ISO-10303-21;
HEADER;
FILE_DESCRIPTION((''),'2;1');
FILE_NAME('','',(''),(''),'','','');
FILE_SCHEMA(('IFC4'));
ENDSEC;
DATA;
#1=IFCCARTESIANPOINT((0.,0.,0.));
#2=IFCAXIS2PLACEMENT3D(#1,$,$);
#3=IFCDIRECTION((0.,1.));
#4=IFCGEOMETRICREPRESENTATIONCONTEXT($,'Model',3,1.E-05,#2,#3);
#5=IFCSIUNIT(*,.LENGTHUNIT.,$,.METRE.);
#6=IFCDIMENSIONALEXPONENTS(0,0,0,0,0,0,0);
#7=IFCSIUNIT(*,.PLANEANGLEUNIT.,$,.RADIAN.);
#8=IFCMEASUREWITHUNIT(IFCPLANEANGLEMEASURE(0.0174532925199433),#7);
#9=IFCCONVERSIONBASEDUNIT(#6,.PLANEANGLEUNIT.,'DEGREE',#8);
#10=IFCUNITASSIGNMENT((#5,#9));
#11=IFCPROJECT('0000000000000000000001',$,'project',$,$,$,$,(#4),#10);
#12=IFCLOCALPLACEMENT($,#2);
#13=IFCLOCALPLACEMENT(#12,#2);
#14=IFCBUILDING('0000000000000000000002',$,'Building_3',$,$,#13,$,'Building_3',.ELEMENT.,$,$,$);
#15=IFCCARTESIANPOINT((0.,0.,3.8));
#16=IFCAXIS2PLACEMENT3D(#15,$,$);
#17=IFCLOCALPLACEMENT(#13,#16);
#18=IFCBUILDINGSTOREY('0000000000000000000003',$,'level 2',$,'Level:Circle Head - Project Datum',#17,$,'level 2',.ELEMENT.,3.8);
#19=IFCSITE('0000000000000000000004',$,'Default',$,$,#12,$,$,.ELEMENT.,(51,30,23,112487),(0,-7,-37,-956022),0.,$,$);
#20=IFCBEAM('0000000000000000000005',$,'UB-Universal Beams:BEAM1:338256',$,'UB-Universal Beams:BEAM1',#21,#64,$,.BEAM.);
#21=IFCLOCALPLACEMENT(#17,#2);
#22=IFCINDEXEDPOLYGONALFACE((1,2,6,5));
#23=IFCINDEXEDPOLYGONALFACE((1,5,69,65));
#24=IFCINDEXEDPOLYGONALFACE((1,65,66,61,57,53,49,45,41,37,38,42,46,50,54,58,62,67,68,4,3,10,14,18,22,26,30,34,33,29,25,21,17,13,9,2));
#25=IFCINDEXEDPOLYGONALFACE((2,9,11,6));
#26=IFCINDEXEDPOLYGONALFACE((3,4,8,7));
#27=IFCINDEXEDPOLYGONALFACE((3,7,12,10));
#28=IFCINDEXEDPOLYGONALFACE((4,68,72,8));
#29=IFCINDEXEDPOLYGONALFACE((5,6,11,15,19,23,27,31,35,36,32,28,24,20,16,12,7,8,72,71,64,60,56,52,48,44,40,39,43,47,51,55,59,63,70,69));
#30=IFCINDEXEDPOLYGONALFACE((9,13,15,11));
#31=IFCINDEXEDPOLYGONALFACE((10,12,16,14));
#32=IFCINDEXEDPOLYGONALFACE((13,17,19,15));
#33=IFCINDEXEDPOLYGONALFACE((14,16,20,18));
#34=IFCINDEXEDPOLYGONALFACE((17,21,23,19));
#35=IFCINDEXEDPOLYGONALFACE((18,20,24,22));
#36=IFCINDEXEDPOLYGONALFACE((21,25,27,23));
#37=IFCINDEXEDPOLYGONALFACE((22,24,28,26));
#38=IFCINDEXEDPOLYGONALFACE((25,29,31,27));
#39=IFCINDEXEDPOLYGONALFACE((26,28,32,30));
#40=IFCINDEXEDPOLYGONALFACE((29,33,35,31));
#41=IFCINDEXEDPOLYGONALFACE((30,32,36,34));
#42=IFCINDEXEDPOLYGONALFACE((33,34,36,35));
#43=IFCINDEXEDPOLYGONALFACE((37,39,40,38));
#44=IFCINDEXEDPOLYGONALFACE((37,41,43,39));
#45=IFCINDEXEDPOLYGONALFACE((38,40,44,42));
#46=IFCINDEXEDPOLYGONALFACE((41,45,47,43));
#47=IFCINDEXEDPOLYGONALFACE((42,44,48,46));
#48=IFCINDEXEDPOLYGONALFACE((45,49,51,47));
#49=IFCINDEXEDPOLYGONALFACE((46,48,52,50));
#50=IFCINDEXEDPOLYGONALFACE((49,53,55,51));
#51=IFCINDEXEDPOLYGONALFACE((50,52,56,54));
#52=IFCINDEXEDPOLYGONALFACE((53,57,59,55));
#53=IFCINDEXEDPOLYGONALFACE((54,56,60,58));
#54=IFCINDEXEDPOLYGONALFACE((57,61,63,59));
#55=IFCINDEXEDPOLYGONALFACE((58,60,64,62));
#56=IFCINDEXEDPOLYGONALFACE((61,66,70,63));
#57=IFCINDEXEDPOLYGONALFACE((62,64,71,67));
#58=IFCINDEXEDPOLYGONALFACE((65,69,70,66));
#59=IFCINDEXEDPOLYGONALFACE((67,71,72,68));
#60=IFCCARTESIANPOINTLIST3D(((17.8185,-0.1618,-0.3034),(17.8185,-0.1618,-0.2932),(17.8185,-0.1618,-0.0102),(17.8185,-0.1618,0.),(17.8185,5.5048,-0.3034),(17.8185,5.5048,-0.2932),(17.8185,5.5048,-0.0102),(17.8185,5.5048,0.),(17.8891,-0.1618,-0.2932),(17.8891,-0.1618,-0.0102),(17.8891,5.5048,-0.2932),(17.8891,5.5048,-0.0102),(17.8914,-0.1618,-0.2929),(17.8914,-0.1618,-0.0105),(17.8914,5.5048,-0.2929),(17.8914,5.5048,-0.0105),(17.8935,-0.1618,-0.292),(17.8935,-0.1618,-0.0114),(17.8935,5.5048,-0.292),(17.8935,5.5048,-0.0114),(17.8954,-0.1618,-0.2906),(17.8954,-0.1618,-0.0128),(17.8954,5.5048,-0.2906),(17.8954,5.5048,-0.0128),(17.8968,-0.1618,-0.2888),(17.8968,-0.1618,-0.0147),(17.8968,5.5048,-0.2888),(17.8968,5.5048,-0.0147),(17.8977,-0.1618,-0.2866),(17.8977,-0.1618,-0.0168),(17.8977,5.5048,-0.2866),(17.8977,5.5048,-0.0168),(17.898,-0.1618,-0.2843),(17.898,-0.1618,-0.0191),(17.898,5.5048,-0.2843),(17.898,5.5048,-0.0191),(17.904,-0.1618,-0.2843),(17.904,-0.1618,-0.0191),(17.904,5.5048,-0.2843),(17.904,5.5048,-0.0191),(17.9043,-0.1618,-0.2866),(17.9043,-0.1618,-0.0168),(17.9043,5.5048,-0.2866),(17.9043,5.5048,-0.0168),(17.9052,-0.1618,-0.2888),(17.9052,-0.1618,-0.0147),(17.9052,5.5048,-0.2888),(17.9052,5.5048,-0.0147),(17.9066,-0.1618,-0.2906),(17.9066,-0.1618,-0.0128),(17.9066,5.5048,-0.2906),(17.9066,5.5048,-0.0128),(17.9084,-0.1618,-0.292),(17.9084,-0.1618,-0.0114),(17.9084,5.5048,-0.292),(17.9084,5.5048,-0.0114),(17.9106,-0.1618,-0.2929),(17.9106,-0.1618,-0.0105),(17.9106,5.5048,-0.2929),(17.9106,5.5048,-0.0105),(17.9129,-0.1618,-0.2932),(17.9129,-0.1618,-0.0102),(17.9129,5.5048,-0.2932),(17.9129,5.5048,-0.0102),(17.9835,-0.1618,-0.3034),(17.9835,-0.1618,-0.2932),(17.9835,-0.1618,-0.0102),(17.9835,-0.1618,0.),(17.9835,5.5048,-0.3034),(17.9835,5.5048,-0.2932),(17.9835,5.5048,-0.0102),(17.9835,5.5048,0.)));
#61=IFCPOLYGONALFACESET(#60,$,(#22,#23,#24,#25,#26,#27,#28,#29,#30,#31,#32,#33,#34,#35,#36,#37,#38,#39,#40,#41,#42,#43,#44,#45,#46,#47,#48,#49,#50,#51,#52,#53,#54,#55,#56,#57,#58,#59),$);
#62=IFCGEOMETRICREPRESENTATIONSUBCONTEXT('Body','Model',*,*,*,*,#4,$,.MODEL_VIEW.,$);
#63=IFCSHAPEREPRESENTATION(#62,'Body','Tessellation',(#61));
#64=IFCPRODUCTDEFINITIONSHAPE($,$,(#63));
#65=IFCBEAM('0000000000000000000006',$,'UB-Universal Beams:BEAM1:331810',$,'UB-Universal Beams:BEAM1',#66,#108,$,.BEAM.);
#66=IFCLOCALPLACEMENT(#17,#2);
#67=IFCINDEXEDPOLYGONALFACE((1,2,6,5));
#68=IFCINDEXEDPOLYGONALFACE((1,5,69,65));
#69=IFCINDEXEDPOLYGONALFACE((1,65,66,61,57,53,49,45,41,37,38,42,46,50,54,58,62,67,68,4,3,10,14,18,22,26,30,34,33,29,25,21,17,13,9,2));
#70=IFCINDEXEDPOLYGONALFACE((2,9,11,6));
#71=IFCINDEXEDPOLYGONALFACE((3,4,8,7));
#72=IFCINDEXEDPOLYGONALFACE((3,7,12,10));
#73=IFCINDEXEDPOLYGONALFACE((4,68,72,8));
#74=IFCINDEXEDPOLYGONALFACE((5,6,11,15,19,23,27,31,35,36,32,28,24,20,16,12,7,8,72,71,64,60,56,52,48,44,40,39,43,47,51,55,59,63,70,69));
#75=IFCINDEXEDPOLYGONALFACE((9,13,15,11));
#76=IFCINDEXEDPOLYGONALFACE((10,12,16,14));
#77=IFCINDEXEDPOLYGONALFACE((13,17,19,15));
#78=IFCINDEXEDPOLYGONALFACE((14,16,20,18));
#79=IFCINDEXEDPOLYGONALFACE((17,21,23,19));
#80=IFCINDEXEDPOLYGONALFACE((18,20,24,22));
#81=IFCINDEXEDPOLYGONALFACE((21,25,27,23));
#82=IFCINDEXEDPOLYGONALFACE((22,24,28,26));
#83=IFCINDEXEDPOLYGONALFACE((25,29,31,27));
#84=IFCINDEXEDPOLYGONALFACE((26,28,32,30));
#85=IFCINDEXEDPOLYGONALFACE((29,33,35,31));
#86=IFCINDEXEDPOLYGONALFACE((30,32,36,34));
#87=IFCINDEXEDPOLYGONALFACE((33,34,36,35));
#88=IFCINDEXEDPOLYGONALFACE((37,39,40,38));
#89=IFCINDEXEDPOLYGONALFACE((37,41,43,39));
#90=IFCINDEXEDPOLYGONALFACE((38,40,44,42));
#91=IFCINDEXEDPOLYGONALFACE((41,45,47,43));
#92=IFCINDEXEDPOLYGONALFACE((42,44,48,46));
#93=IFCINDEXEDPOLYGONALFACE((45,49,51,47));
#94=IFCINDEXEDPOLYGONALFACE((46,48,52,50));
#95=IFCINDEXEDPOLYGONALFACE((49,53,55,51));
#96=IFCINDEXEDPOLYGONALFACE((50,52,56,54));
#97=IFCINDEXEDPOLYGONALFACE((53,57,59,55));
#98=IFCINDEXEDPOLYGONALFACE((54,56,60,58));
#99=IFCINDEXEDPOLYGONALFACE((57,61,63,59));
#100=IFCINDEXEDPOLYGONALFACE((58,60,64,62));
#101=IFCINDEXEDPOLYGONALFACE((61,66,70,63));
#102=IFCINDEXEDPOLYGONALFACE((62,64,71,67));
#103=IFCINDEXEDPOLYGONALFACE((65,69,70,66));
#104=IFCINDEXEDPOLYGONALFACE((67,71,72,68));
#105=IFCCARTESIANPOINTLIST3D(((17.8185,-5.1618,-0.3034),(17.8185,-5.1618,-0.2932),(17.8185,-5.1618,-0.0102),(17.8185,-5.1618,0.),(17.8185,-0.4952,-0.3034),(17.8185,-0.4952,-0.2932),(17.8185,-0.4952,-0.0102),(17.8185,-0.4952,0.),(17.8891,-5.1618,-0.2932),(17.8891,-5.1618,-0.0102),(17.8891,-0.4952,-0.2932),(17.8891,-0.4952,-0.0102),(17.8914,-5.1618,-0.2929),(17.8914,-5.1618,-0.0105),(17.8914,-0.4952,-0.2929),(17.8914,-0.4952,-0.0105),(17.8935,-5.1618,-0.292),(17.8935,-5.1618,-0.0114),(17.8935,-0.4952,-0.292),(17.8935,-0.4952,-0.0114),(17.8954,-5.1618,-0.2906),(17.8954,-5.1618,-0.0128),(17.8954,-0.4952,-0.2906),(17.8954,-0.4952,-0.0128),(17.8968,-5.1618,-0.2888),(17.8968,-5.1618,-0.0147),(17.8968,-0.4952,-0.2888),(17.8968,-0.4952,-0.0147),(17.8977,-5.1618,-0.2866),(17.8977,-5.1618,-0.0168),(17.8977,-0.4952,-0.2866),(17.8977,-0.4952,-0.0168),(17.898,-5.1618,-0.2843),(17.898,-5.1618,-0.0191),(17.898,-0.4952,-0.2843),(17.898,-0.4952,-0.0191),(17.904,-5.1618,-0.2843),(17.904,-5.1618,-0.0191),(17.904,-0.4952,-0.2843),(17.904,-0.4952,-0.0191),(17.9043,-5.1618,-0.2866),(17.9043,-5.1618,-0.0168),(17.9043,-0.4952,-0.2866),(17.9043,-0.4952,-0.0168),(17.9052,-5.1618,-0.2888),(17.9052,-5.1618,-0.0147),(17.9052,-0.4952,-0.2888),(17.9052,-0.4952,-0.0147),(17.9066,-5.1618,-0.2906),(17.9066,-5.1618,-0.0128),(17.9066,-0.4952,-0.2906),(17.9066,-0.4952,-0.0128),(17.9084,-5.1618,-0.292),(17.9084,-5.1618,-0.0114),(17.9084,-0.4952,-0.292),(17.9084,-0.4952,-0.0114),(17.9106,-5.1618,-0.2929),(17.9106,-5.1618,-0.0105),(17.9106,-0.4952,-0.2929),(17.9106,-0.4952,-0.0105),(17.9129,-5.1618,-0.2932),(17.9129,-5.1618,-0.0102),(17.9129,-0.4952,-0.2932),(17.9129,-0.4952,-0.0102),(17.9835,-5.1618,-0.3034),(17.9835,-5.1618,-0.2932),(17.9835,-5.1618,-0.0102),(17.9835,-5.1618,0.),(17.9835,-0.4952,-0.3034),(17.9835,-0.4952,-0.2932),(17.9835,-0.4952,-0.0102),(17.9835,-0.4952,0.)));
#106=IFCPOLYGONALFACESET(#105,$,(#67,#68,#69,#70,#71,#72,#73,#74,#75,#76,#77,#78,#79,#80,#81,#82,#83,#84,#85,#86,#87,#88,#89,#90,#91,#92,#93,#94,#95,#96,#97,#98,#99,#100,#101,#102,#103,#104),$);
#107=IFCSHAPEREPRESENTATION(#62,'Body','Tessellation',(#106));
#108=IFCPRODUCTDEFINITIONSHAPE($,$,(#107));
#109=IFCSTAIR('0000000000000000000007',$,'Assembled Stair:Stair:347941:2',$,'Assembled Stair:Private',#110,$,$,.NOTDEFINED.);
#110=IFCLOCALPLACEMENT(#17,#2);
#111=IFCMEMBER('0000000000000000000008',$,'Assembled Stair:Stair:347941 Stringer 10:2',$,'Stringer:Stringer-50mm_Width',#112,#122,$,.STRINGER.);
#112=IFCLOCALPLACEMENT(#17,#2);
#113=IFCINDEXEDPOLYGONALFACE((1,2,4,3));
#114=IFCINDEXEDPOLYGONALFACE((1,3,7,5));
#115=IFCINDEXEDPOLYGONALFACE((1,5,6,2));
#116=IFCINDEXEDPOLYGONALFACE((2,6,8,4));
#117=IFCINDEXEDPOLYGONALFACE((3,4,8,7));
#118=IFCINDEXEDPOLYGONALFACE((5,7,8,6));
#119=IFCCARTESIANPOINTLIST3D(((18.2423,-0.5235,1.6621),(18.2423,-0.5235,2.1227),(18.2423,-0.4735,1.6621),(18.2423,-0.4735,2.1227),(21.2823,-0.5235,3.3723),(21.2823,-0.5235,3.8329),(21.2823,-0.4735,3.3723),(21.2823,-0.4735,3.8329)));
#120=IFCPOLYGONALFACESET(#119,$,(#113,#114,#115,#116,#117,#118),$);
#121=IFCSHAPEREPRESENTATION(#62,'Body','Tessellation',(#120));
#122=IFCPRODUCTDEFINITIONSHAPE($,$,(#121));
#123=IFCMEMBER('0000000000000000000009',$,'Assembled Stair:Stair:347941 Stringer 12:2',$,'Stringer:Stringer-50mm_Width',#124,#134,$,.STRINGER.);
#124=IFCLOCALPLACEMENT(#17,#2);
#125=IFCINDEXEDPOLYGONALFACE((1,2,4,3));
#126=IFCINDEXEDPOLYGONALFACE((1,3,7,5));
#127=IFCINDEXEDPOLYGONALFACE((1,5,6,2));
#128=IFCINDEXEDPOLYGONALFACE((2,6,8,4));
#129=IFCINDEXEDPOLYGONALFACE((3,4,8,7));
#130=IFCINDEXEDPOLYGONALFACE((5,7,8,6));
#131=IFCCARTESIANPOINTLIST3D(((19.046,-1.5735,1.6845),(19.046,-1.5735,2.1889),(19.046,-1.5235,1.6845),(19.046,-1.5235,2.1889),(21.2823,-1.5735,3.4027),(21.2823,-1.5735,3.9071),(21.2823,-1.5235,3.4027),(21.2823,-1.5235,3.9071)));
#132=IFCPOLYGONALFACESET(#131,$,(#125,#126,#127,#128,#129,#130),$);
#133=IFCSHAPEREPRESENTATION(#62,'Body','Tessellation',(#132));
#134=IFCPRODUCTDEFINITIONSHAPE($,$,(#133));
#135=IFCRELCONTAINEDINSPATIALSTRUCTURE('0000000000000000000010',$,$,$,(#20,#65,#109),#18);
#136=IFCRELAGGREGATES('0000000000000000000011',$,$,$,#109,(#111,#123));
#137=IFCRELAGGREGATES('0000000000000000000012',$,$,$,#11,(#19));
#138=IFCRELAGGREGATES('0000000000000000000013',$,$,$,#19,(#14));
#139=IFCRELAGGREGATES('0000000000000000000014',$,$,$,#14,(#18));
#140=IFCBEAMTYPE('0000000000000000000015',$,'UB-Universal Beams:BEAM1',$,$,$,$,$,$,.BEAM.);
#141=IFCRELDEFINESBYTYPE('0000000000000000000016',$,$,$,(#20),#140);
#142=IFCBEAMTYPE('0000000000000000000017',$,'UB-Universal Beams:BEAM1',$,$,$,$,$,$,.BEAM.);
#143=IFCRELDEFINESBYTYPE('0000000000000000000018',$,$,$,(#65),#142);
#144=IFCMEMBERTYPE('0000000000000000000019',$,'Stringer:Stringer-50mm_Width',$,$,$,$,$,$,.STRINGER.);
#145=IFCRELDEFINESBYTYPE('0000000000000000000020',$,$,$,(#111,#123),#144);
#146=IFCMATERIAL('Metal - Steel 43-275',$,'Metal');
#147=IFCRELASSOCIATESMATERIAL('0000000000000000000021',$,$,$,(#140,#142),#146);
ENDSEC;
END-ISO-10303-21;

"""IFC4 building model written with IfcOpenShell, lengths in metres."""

from ifc_helpers import new_model, entity, si_unit, converted_unit, direction, frame, frame_2d, origin, place, context, subcontext, project, spatial, polyline, circle_curve, parameter, trimmed, segment, composite_curve, outline, extrude, source, transform, mapped, material, material_profile, profile_set, type_object, type_shapes, element, aggregate, save


model = new_model("IFC4")

# Units and contexts
model_context = context("Model", 3, precision=1e-05, world=origin(), true_north=direction((0.0, 1.0)))
body_context = subcontext(model_context, "Body", "Model", "MODEL_VIEW")
ifc_project = project(units=[si_unit("LENGTHUNIT", "METRE"), converted_unit("PLANEANGLEUNIT", "DEGREE", entity("IfcPlaneAngleMeasure", 0.0174532925199433), si_unit("PLANEANGLEUNIT", "RADIAN"), dimensions=[0, 0, 0, 0, 0, 0, 0])], contexts=[model_context])

# Site, building, storey
site_placement = place(None, origin())
site = spatial("IfcSite", under=ifc_project, at=site_placement, Name="Default", CompositionType="ELEMENT", RefLatitude=(51, 30, 23, 112487), RefLongitude=(0, -7, -37, -956022), RefElevation=0.0)
building_placement = place(site_placement, origin())
building = spatial("IfcBuilding", under=site, at=building_placement, Name="Building_3", LongName="Building_3", CompositionType="ELEMENT")
storey_placement = place(building_placement, frame((0.0, 0.0, 3.8)))
storey = spatial("IfcBuildingStorey", under=building, at=storey_placement, Name="level 2", ObjectType="Level:Circle Head - Project Datum", LongName="level 2", CompositionType="ELEMENT", Elevation=3.8)

# Beams
ifc_material_1 = material(Name="Metal - Steel 43-275", Category="Metal")
ifc_material_profile = material_profile(ifc_material_1, outline(composite_curve([segment(polyline([(-0.0825, -0.1415), (-0.0825, -0.1517)]), True, "CONTINUOUS"), segment(polyline([(-0.0825, -0.1517), (0.0825, -0.1517)]), True, "CONTINUOUS"), segment(polyline([(0.0825, -0.1517), (0.0825, -0.1415)]), True, "CONTINUOUS"), segment(polyline([(0.0825, -0.1415), (0.0119, -0.1415)]), True, "CONTINUOUS"), segment(trimmed(circle_curve(frame_2d((0.0119, -0.1326), x_axis=(1.0, 0.0)), 0.0089), [parameter(180.0)], [parameter(270.0)], True, "PARAMETER"), False, "CONTINUOUS"), segment(polyline([(0.003, -0.1326), (0.003, 0.1326)]), True, "CONTINUOUS"), segment(trimmed(circle_curve(frame_2d((0.0119, 0.1326), x_axis=(1.0, 0.0)), 0.0089), [parameter(90.0)], [parameter(180.0)], True, "PARAMETER"), False, "CONTINUOUS"), segment(polyline([(0.0119, 0.1415), (0.0825, 0.1415)]), True, "CONTINUOUS"), segment(polyline([(0.0825, 0.1415), (0.0825, 0.1517)]), True, "CONTINUOUS"), segment(polyline([(0.0825, 0.1517), (-0.0825, 0.1517)]), True, "CONTINUOUS"), segment(polyline([(-0.0825, 0.1517), (-0.0825, 0.1415)]), True, "CONTINUOUS"), segment(polyline([(-0.0825, 0.1415), (-0.0119, 0.1415)]), True, "CONTINUOUS"), segment(trimmed(circle_curve(frame_2d((-0.0119, 0.1326), x_axis=(1.0, 0.0)), 0.0089), [parameter(360.0)], [parameter(90.0)], True, "PARAMETER"), False, "CONTINUOUS"), segment(polyline([(-0.003, 0.1326), (-0.003, -0.1326)]), True, "CONTINUOUS"), segment(trimmed(circle_curve(frame_2d((-0.0119, -0.1326), x_axis=(1.0, 0.0)), 0.0089), [parameter(270.0)], [parameter(360.0)], True, "PARAMETER"), False, "CONTINUOUS"), segment(polyline([(-0.0119, -0.1415), (-0.0825, -0.1415)]), True, "CONTINUOUS")], self_intersect=False)), Name="BEAM1")
ifc_profile_set = profile_set([ifc_material_profile], Name="BEAM1")
beam_type_1 = type_object("IfcBeamType", Name="UB-Universal Beams:BEAM1", PredefinedType="BEAM", material=ifc_profile_set)
shared_shape_1 = source(origin(), body_context, "Body", "SweptSolid", [
    extrude(outline(composite_curve([segment(polyline([(-0.0825, -0.1415), (-0.0825, -0.1517)]), True, "CONTINUOUS"), segment(polyline([(-0.0825, -0.1517), (0.0825, -0.1517)]), True, "CONTINUOUS"), segment(polyline([(0.0825, -0.1517), (0.0825, -0.1415)]), True, "CONTINUOUS"), segment(polyline([(0.0825, -0.1415), (0.0119, -0.1415)]), True, "CONTINUOUS"), segment(trimmed(circle_curve(frame_2d((0.0119, -0.1326), x_axis=(1.0, 0.0)), 0.0089), [parameter(180.0)], [parameter(270.0)], True, "PARAMETER"), False, "CONTINUOUS"), segment(polyline([(0.003, -0.1326), (0.003, 0.1326)]), True, "CONTINUOUS"), segment(trimmed(circle_curve(frame_2d((0.0119, 0.1326), x_axis=(1.0, 0.0)), 0.0089), [parameter(90.0)], [parameter(180.0)], True, "PARAMETER"), False, "CONTINUOUS"), segment(polyline([(0.0119, 0.1415), (0.0825, 0.1415)]), True, "CONTINUOUS"), segment(polyline([(0.0825, 0.1415), (0.0825, 0.1517)]), True, "CONTINUOUS"), segment(polyline([(0.0825, 0.1517), (-0.0825, 0.1517)]), True, "CONTINUOUS"), segment(polyline([(-0.0825, 0.1517), (-0.0825, 0.1415)]), True, "CONTINUOUS"), segment(polyline([(-0.0825, 0.1415), (-0.0119, 0.1415)]), True, "CONTINUOUS"), segment(trimmed(circle_curve(frame_2d((-0.0119, 0.1326), x_axis=(1.0, 0.0)), 0.0089), [parameter(360.0)], [parameter(90.0)], True, "PARAMETER"), False, "CONTINUOUS"), segment(polyline([(-0.003, 0.1326), (-0.003, -0.1326)]), True, "CONTINUOUS"), segment(trimmed(circle_curve(frame_2d((-0.0119, -0.1326), x_axis=(1.0, 0.0)), 0.0089), [parameter(270.0)], [parameter(360.0)], True, "PARAMETER"), False, "CONTINUOUS"), segment(polyline([(-0.0119, -0.1415), (-0.0825, -0.1415)]), True, "CONTINUOUS")], self_intersect=False)), frame((-2.8333, 0.0, 0.0), z_axis=(-1.0, 0.0, 0.0), x_axis=(0.0, -1.0, 0.0)), (0.0, 0.0, -1.0), 5.6666),
])
type_shapes(beam_type_1, [shared_shape_1])
for number, where, z_axis, x_axis, name in (
    (1, (17.901, 2.6715, -0.1517), (0.0, 0.0, 1.0), (0.0, -1.0, 0.0), "UB-Universal Beams:BEAM1:338256"),
):
    element("IfcBeam", number, at=place(storey_placement, frame(where, z_axis=z_axis, x_axis=x_axis)), inside=storey, type_object=beam_type_1, Name=name, ObjectType="UB-Universal Beams:BEAM1", PredefinedType="BEAM", context=body_context, shape_type="MappedRepresentation", body=[
        mapped(shared_shape_1, transform((0.0, 0.0, 0.0), scale=1.0)),
    ])
beam_type_2 = type_object("IfcBeamType", Name="UB-Universal Beams:BEAM1", PredefinedType="BEAM", material=ifc_profile_set)
shared_shape_2 = source(origin(), body_context, "Body", "SweptSolid", [
    extrude(outline(composite_curve([segment(polyline([(-0.0825, -0.1415), (-0.0825, -0.1517)]), True, "CONTINUOUS"), segment(polyline([(-0.0825, -0.1517), (0.0825, -0.1517)]), True, "CONTINUOUS"), segment(polyline([(0.0825, -0.1517), (0.0825, -0.1415)]), True, "CONTINUOUS"), segment(polyline([(0.0825, -0.1415), (0.0119, -0.1415)]), True, "CONTINUOUS"), segment(trimmed(circle_curve(frame_2d((0.0119, -0.1326), x_axis=(0.0, -1.0)), 0.0089), [parameter(270.0)], [parameter(360.0)], True, "PARAMETER"), False, "CONTINUOUS"), segment(polyline([(0.003, -0.1326), (0.003, 0.1326)]), True, "CONTINUOUS"), segment(trimmed(circle_curve(frame_2d((0.0119, 0.1326), x_axis=(-1.0, 0.0)), 0.0089), [parameter(270.0)], [parameter(360.0)], True, "PARAMETER"), False, "CONTINUOUS"), segment(polyline([(0.0119, 0.1415), (0.0825, 0.1415)]), True, "CONTINUOUS"), segment(polyline([(0.0825, 0.1415), (0.0825, 0.1517)]), True, "CONTINUOUS"), segment(polyline([(0.0825, 0.1517), (-0.0825, 0.1517)]), True, "CONTINUOUS"), segment(polyline([(-0.0825, 0.1517), (-0.0825, 0.1415)]), True, "CONTINUOUS"), segment(polyline([(-0.0825, 0.1415), (-0.0119, 0.1415)]), True, "CONTINUOUS"), segment(trimmed(circle_curve(frame_2d((-0.0119, 0.1326), x_axis=(0.0, 1.0)), 0.0089), [parameter(270.0)], [parameter(360.0)], True, "PARAMETER"), False, "CONTINUOUS"), segment(polyline([(-0.003, 0.1326), (-0.003, -0.1326)]), True, "CONTINUOUS"), segment(trimmed(circle_curve(frame_2d((-0.0119, -0.1326), x_axis=(1.0, 0.0)), 0.0089), [parameter(270.0)], [parameter(0.0)], True, "PARAMETER"), False, "CONTINUOUS"), segment(polyline([(-0.0119, -0.1415), (-0.0825, -0.1415)]), True, "CONTINUOUS")], self_intersect=False)), frame((-2.3333, 0.0, 0.0), z_axis=(-1.0, 0.0, 0.0), x_axis=(0.0, -1.0, 0.0)), (0.0, 0.0, -1.0), 4.6666),
])
type_shapes(beam_type_2, [shared_shape_2])
beam_placement = place(storey_placement, frame((17.901, -2.8285, -0.1517), z_axis=(0.0, 0.0, 1.0), x_axis=(0.0, -1.0, 0.0)))
element("IfcBeam", 2, at=beam_placement, inside=storey, type_object=beam_type_2, Name="UB-Universal Beams:BEAM1:331810", ObjectType="UB-Universal Beams:BEAM1", PredefinedType="BEAM", context=body_context, shape_type="MappedRepresentation", body=[
    mapped(shared_shape_2, transform((0.0, 0.0, 0.0), scale=1.0)),
])

# Stair, members
stair_placement = place(storey_placement, origin())
stair = element("IfcStair", 3, at=stair_placement, inside=storey, Name="Assembled Stair:Stair:347941:2", ObjectType="Assembled Stair:Private", PredefinedType="NOTDEFINED")
member_type = type_object("IfcMemberType", Name="Stringer:Stringer-50mm_Width", PredefinedType="STRINGER")
member_1_placement = place(stair_placement, frame((18.2423, -0.5235, 1.6621)))
member_1 = element("IfcMember", 4, at=member_1_placement, type_object=member_type, Name="Assembled Stair:Stair:347941 Stringer 10:2", ObjectType="Stringer:Stringer-50mm_Width", PredefinedType="STRINGER", context=body_context, shape_type="SweptSolid", body=[
    extrude(outline(polyline([(-1.6311, -0.2007), (1.857, -0.2007), (1.6311, 0.2007), (-1.857, 0.2007), (-1.6311, -0.2007)])), frame((1.52, 0.0, 1.0854), z_axis=(0.0, 1.0, 0.0), x_axis=(0.871553, 0.0, 0.490302)), (0.0, 0.0, 1.0), 0.05),
])
member_2_placement = place(stair_placement, frame((19.046, -1.5735, 1.6845)))
member_2 = element("IfcMember", 5, at=member_2_placement, type_object=member_type, Name="Assembled Stair:Stair:347941 Stringer 12:2", ObjectType="Stringer:Stringer-50mm_Width", PredefinedType="STRINGER", context=body_context, shape_type="SweptSolid", body=[
    extrude(outline(polyline([(-1.2564, -0.2), (1.5637, -0.2), (1.2564, 0.2), (-1.5637, 0.2), (-1.2564, -0.2)])), frame((1.1182, 0.0, 1.1113), z_axis=(0.0, 1.0, 0.0), x_axis=(0.792984, 0.0, 0.609242)), (0.0, 0.0, 1.0), 0.05),
])
aggregate(stair, [member_1, member_2])

save(model, "model.ifc")
